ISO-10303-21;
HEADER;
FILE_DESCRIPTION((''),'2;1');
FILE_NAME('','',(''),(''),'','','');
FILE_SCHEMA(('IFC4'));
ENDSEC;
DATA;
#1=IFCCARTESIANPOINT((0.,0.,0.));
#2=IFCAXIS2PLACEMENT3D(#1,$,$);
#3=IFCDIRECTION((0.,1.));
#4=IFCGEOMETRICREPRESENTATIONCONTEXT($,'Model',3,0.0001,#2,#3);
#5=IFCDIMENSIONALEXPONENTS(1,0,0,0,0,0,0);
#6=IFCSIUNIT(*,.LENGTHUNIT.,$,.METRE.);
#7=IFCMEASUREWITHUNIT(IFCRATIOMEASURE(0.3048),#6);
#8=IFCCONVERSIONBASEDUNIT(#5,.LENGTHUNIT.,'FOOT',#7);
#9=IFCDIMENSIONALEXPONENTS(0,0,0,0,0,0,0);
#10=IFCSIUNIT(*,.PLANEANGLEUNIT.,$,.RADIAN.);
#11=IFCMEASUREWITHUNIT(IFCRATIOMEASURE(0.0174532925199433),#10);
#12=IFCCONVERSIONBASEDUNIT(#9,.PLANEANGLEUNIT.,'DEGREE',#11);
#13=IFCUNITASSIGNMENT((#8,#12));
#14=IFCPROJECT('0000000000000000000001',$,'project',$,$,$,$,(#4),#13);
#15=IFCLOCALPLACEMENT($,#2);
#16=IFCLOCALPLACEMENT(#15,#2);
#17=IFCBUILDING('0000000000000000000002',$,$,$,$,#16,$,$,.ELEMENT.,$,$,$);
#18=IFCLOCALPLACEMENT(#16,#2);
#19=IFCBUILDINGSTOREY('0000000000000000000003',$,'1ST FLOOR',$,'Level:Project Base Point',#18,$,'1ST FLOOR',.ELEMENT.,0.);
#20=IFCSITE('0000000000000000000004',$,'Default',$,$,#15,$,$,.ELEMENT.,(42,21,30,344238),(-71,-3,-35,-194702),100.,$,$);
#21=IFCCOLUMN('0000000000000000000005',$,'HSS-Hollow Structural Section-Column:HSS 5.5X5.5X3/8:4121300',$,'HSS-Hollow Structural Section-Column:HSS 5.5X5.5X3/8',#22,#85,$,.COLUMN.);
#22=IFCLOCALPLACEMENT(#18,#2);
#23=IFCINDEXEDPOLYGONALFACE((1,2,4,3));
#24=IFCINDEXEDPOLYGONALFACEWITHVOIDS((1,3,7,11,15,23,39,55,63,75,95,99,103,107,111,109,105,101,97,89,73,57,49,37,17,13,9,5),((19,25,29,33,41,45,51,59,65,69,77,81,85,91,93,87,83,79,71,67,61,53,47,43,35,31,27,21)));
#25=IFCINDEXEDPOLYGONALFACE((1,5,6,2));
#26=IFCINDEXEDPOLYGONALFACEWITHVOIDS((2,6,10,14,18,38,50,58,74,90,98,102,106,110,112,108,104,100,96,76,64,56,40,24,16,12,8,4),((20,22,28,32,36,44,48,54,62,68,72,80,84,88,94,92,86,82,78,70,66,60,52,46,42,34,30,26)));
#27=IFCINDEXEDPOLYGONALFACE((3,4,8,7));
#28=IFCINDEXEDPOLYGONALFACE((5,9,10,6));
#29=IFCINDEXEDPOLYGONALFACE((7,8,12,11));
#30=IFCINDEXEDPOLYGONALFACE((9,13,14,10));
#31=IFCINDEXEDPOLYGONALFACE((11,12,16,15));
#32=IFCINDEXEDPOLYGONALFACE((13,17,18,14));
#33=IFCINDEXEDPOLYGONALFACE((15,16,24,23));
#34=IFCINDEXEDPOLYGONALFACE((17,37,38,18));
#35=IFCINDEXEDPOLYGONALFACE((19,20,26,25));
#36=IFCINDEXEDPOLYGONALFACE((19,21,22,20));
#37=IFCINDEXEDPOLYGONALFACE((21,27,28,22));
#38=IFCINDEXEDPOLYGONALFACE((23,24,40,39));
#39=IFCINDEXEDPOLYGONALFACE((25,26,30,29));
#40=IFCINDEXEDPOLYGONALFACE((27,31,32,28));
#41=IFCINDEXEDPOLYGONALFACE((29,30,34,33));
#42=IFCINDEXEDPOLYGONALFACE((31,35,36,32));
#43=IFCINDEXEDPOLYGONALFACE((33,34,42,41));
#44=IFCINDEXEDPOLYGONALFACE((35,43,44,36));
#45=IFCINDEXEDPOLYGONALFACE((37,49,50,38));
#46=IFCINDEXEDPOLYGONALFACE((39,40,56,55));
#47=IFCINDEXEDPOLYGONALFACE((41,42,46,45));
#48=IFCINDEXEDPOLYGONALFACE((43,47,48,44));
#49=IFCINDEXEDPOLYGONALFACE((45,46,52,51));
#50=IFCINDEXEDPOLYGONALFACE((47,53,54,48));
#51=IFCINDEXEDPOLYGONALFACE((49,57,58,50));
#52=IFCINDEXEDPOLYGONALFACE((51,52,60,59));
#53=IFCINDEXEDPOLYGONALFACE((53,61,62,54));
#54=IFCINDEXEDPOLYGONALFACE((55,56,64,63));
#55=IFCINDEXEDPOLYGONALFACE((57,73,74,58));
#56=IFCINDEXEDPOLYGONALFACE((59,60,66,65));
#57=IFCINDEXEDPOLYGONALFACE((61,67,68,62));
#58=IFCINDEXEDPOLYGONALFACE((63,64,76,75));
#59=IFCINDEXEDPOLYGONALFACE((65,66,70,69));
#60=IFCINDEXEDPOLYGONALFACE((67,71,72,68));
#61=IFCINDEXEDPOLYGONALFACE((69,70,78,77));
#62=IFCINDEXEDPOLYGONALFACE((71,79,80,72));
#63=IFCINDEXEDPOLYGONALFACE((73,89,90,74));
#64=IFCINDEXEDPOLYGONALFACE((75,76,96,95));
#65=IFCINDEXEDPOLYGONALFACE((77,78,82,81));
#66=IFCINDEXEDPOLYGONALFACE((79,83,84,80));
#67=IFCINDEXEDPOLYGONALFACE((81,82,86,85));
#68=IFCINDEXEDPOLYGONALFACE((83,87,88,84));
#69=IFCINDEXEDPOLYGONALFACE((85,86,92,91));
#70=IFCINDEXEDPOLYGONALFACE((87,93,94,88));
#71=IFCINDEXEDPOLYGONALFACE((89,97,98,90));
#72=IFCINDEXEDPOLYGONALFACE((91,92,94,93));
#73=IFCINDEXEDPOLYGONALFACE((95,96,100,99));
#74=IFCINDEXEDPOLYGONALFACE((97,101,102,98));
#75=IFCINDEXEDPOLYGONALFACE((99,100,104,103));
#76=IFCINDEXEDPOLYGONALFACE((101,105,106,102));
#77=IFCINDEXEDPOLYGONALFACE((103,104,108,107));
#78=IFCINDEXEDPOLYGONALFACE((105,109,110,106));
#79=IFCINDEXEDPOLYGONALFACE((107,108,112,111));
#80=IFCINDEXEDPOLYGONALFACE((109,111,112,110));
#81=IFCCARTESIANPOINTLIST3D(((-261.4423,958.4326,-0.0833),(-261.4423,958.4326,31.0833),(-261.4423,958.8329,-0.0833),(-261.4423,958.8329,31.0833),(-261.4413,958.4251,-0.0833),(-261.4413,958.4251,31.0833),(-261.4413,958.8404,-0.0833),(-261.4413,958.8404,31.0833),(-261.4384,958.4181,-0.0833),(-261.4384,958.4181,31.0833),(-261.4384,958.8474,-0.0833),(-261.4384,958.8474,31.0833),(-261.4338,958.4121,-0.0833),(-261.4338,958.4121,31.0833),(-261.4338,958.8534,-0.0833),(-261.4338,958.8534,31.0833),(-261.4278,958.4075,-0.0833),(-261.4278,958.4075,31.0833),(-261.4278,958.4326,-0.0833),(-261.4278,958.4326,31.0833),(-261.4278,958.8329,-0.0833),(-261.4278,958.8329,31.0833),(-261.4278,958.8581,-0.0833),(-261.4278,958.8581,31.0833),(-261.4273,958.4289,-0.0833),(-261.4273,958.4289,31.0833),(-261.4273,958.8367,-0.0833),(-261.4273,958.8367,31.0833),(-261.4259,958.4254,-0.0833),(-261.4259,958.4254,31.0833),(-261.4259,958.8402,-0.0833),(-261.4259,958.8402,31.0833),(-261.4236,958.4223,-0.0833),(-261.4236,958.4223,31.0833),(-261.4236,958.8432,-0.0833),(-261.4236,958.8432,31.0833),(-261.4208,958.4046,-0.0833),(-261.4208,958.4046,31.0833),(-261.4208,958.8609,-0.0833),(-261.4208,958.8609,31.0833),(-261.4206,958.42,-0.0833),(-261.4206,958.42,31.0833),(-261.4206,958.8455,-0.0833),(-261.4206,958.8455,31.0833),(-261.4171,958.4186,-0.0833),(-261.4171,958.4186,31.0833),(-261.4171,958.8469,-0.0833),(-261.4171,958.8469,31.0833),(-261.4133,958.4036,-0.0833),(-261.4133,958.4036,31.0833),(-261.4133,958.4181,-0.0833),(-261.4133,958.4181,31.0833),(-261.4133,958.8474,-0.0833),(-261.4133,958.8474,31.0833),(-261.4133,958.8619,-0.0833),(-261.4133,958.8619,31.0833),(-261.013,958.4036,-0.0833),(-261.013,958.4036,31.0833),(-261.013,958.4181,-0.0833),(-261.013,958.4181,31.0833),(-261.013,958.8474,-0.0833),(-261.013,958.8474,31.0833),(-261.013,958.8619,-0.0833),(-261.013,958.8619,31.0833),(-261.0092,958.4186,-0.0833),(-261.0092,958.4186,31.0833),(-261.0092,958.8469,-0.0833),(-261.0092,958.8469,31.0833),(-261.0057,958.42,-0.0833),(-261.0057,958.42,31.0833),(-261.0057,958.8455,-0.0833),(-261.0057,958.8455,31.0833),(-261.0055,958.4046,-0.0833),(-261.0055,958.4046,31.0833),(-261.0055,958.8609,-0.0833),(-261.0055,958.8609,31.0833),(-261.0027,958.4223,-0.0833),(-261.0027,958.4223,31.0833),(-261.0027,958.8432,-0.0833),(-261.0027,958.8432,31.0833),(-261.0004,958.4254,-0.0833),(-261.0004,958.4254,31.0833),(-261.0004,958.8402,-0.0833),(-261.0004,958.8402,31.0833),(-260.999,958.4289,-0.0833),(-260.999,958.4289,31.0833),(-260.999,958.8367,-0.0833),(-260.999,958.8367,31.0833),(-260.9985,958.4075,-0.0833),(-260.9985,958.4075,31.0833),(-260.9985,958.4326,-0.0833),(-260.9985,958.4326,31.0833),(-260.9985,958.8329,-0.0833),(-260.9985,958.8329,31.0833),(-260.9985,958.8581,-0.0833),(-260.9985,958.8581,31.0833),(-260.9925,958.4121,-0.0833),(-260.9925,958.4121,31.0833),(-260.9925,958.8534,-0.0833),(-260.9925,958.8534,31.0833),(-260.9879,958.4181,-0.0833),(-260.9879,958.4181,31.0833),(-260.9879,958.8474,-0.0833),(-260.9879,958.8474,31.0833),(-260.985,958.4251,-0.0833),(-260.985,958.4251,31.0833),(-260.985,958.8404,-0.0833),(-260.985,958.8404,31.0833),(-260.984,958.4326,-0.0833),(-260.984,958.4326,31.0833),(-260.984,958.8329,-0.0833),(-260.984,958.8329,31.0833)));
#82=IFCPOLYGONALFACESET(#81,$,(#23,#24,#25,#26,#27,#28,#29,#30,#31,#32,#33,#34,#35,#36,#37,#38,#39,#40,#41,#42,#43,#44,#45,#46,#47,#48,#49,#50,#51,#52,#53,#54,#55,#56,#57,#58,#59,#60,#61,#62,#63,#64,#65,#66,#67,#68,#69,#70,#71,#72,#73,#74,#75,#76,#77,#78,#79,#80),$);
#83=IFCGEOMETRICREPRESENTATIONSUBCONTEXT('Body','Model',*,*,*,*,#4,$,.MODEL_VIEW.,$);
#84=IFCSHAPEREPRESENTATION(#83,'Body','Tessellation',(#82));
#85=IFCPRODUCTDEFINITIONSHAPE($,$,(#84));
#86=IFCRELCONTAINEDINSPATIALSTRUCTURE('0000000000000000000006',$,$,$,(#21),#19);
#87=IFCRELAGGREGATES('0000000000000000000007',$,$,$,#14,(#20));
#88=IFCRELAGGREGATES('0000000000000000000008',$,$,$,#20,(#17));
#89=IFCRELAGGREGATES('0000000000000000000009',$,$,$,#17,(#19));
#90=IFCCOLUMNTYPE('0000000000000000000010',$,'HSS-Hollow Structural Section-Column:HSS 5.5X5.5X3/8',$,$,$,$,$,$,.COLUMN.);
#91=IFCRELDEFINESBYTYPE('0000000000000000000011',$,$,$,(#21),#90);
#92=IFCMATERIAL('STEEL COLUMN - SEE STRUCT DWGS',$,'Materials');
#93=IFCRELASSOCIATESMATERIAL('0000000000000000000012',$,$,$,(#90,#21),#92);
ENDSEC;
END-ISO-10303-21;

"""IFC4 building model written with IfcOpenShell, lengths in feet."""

from ifc_helpers import new_model, entity, si_unit, converted_unit, direction, frame, frame_2d, origin, place, context, subcontext, project, spatial, polyline, circle_curve, parameter, trimmed, segment, composite_curve, outline, extrude, source, transform, mapped, material, material_profile, profile_set, profile_usage, type_object, type_shapes, element, save


model = new_model("IFC4")

# Units and contexts
model_context = context("Model", 3, precision=0.0001, world=origin(), true_north=direction((0.0, 1.0)))
body_context = subcontext(model_context, "Body", "Model", "MODEL_VIEW")
ifc_project = project(units=[converted_unit("LENGTHUNIT", "FOOT", entity("IfcRatioMeasure", 0.3048), si_unit("LENGTHUNIT", "METRE"), dimensions=[1, 0, 0, 0, 0, 0, 0]), converted_unit("PLANEANGLEUNIT", "DEGREE", entity("IfcRatioMeasure", 0.0174532925199433), si_unit("PLANEANGLEUNIT", "RADIAN"), dimensions=[0, 0, 0, 0, 0, 0, 0])], contexts=[model_context])

# Site, building, storey
site_placement = place(None, origin())
site = spatial("IfcSite", under=ifc_project, at=site_placement, Name="Default", CompositionType="ELEMENT", RefLatitude=(42, 21, 30, 344238), RefLongitude=(-71, -3, -35, -194702), RefElevation=100.0)
building_placement = place(site_placement, origin())
building = spatial("IfcBuilding", under=site, at=building_placement, CompositionType="ELEMENT")
storey_placement = place(building_placement, origin())
storey = spatial("IfcBuildingStorey", under=building, at=storey_placement, Name="1ST FLOOR", ObjectType="Level:Project Base Point", LongName="1ST FLOOR", CompositionType="ELEMENT", Elevation=0.0)

# Column
ifc_material_1 = material(Name="STEEL COLUMN - SEE STRUCT DWGS", Category="Materials")
ifc_material_profile_1 = material_profile(ifc_material_1, outline(composite_curve([segment(trimmed(circle_curve(frame_2d((0.2002, -0.2002), x_axis=(1.0, 0.0)), 0.029), [parameter(270.0)], [parameter(0.0)], True, "PARAMETER"), True, "CONTINUOUS"), segment(polyline([(0.2292, -0.2002), (0.2292, 0.2002)]), True, "CONTINUOUS"), segment(trimmed(circle_curve(frame_2d((0.2002, 0.2002), x_axis=(1.0, 0.0)), 0.029), [parameter(0.0)], [parameter(90.0)], True, "PARAMETER"), True, "CONTINUOUS"), segment(polyline([(0.2002, 0.2292), (-0.2002, 0.2292)]), True, "CONTINUOUS"), segment(trimmed(circle_curve(frame_2d((-0.2002, 0.2002), x_axis=(1.0, 0.0)), 0.029), [parameter(90.0)], [parameter(180.0)], True, "PARAMETER"), True, "CONTINUOUS"), segment(polyline([(-0.2292, 0.2002), (-0.2292, -0.2002)]), True, "CONTINUOUS"), segment(trimmed(circle_curve(frame_2d((-0.2002, -0.2002), x_axis=(1.0, 0.0)), 0.029), [parameter(180.0)], [parameter(270.0)], True, "PARAMETER"), True, "CONTINUOUS"), segment(polyline([(-0.2002, -0.2292), (0.2002, -0.2292)]), True, "CONTINUOUS")], self_intersect=False), holes=[composite_curve([segment(polyline([(0.2002, -0.2147), (-0.2002, -0.2147)]), True, "CONTINUOUS"), segment(trimmed(circle_curve(frame_2d((-0.2002, -0.2002), x_axis=(1.0, 0.0)), 0.0145), [parameter(180.0)], [parameter(270.0)], True, "PARAMETER"), False, "CONTINUOUS"), segment(polyline([(-0.2147, -0.2002), (-0.2147, 0.2002)]), True, "CONTINUOUS"), segment(trimmed(circle_curve(frame_2d((-0.2002, 0.2002), x_axis=(1.0, 0.0)), 0.0145), [parameter(90.0)], [parameter(180.0)], True, "PARAMETER"), False, "CONTINUOUS"), segment(polyline([(-0.2002, 0.2147), (0.2002, 0.2147)]), True, "CONTINUOUS"), segment(trimmed(circle_curve(frame_2d((0.2002, 0.2002), x_axis=(1.0, 0.0)), 0.0145), [parameter(0.0)], [parameter(90.0)], True, "PARAMETER"), False, "CONTINUOUS"), segment(polyline([(0.2147, 0.2002), (0.2147, -0.2002)]), True, "CONTINUOUS"), segment(trimmed(circle_curve(frame_2d((0.2002, -0.2002), x_axis=(1.0, 0.0)), 0.0145), [parameter(270.0)], [parameter(0.0)], True, "PARAMETER"), False, "CONTINUOUS")], self_intersect=False)]), Name="HSS 5.5X5.5X3/8")
ifc_profile_set_1 = profile_set([ifc_material_profile_1], Name="HSS 5.5X5.5X3/8")
ifc_profile_usage_1 = profile_usage(ifc_profile_set_1)
column_type_1 = type_object("IfcColumnType", Name="HSS-Hollow Structural Section-Column:HSS 5.5X5.5X3/8", PredefinedType="COLUMN", material=ifc_profile_set_1)
shared_shape_1 = source(origin(), body_context, "Body", "SweptSolid", [
    extrude(outline(composite_curve([segment(polyline([(-0.2002, -0.2292), (0.2002, -0.2292)]), True, "CONTINUOUS"), segment(trimmed(circle_curve(frame_2d((0.2002, -0.2002), x_axis=(-1.0, 0.0)), 0.029), [parameter(90.0)], [parameter(180.0)], True, "PARAMETER"), True, "CONTINUOUS"), segment(polyline([(0.2292, -0.2002), (0.2292, 0.2002)]), True, "CONTINUOUS"), segment(trimmed(circle_curve(frame_2d((0.2002, 0.2002), x_axis=(-1.0, 0.0)), 0.029), [parameter(180.0)], [parameter(270.0)], True, "PARAMETER"), True, "CONTINUOUS"), segment(polyline([(0.2002, 0.2292), (-0.2002, 0.2292)]), True, "CONTINUOUS"), segment(trimmed(circle_curve(frame_2d((-0.2002, 0.2002), x_axis=(-1.0, 0.0)), 0.029), [parameter(270.0)], [parameter(360.0)], True, "PARAMETER"), True, "CONTINUOUS"), segment(polyline([(-0.2292, 0.2002), (-0.2292, -0.2002)]), True, "CONTINUOUS"), segment(trimmed(circle_curve(frame_2d((-0.2002, -0.2002), x_axis=(-1.0, 0.0)), 0.029), [parameter(360.0)], [parameter(90.0)], True, "PARAMETER"), True, "CONTINUOUS")], self_intersect=False), holes=[composite_curve([segment(trimmed(circle_curve(frame_2d((-0.2002, -0.2002), x_axis=(-1.0, 0.0)), 0.0145), [parameter(0.0)], [parameter(90.0)], True, "PARAMETER"), False, "CONTINUOUS"), segment(polyline([(-0.2147, -0.2002), (-0.2147, 0.2002)]), True, "CONTINUOUS"), segment(trimmed(circle_curve(frame_2d((-0.2002, 0.2002), x_axis=(-1.0, 0.0)), 0.0145), [parameter(270.0)], [parameter(360.0)], True, "PARAMETER"), False, "CONTINUOUS"), segment(polyline([(-0.2002, 0.2147), (0.2002, 0.2147)]), True, "CONTINUOUS"), segment(trimmed(circle_curve(frame_2d((0.2002, 0.2002), x_axis=(-1.0, 0.0)), 0.0145), [parameter(180.0)], [parameter(270.0)], True, "PARAMETER"), False, "CONTINUOUS"), segment(polyline([(0.2147, 0.2002), (0.2147, -0.2002)]), True, "CONTINUOUS"), segment(trimmed(circle_curve(frame_2d((0.2002, -0.2002), x_axis=(-1.0, 0.0)), 0.0145), [parameter(90.0)], [parameter(180.0)], True, "PARAMETER"), False, "CONTINUOUS"), segment(polyline([(0.2002, -0.2147), (-0.2002, -0.2147)]), True, "CONTINUOUS")], self_intersect=False)]), frame((0.0, 0.0, -0.0833), z_axis=(0.0, 0.0, 1.0), x_axis=(-1.0, 0.0, 0.0)), (0.0, 0.0, 1.0), 31.1667),
])
type_shapes(column_type_1, [shared_shape_1])
column_1_placement = place(storey_placement, frame((-261.2132, 958.6328, 0.0)))
element("IfcColumn", 1, at=column_1_placement, inside=storey, type_object=column_type_1, material=ifc_profile_usage_1, Name="HSS-Hollow Structural Section-Column:HSS 5.5X5.5X3/8:4121300", ObjectType="HSS-Hollow Structural Section-Column:HSS 5.5X5.5X3/8", PredefinedType="COLUMN", context=body_context, shape_type="MappedRepresentation", body=[
    mapped(shared_shape_1, transform((0.0, 0.0, 0.0), scale=1.0)),
])

save(model, "model.ifc")
